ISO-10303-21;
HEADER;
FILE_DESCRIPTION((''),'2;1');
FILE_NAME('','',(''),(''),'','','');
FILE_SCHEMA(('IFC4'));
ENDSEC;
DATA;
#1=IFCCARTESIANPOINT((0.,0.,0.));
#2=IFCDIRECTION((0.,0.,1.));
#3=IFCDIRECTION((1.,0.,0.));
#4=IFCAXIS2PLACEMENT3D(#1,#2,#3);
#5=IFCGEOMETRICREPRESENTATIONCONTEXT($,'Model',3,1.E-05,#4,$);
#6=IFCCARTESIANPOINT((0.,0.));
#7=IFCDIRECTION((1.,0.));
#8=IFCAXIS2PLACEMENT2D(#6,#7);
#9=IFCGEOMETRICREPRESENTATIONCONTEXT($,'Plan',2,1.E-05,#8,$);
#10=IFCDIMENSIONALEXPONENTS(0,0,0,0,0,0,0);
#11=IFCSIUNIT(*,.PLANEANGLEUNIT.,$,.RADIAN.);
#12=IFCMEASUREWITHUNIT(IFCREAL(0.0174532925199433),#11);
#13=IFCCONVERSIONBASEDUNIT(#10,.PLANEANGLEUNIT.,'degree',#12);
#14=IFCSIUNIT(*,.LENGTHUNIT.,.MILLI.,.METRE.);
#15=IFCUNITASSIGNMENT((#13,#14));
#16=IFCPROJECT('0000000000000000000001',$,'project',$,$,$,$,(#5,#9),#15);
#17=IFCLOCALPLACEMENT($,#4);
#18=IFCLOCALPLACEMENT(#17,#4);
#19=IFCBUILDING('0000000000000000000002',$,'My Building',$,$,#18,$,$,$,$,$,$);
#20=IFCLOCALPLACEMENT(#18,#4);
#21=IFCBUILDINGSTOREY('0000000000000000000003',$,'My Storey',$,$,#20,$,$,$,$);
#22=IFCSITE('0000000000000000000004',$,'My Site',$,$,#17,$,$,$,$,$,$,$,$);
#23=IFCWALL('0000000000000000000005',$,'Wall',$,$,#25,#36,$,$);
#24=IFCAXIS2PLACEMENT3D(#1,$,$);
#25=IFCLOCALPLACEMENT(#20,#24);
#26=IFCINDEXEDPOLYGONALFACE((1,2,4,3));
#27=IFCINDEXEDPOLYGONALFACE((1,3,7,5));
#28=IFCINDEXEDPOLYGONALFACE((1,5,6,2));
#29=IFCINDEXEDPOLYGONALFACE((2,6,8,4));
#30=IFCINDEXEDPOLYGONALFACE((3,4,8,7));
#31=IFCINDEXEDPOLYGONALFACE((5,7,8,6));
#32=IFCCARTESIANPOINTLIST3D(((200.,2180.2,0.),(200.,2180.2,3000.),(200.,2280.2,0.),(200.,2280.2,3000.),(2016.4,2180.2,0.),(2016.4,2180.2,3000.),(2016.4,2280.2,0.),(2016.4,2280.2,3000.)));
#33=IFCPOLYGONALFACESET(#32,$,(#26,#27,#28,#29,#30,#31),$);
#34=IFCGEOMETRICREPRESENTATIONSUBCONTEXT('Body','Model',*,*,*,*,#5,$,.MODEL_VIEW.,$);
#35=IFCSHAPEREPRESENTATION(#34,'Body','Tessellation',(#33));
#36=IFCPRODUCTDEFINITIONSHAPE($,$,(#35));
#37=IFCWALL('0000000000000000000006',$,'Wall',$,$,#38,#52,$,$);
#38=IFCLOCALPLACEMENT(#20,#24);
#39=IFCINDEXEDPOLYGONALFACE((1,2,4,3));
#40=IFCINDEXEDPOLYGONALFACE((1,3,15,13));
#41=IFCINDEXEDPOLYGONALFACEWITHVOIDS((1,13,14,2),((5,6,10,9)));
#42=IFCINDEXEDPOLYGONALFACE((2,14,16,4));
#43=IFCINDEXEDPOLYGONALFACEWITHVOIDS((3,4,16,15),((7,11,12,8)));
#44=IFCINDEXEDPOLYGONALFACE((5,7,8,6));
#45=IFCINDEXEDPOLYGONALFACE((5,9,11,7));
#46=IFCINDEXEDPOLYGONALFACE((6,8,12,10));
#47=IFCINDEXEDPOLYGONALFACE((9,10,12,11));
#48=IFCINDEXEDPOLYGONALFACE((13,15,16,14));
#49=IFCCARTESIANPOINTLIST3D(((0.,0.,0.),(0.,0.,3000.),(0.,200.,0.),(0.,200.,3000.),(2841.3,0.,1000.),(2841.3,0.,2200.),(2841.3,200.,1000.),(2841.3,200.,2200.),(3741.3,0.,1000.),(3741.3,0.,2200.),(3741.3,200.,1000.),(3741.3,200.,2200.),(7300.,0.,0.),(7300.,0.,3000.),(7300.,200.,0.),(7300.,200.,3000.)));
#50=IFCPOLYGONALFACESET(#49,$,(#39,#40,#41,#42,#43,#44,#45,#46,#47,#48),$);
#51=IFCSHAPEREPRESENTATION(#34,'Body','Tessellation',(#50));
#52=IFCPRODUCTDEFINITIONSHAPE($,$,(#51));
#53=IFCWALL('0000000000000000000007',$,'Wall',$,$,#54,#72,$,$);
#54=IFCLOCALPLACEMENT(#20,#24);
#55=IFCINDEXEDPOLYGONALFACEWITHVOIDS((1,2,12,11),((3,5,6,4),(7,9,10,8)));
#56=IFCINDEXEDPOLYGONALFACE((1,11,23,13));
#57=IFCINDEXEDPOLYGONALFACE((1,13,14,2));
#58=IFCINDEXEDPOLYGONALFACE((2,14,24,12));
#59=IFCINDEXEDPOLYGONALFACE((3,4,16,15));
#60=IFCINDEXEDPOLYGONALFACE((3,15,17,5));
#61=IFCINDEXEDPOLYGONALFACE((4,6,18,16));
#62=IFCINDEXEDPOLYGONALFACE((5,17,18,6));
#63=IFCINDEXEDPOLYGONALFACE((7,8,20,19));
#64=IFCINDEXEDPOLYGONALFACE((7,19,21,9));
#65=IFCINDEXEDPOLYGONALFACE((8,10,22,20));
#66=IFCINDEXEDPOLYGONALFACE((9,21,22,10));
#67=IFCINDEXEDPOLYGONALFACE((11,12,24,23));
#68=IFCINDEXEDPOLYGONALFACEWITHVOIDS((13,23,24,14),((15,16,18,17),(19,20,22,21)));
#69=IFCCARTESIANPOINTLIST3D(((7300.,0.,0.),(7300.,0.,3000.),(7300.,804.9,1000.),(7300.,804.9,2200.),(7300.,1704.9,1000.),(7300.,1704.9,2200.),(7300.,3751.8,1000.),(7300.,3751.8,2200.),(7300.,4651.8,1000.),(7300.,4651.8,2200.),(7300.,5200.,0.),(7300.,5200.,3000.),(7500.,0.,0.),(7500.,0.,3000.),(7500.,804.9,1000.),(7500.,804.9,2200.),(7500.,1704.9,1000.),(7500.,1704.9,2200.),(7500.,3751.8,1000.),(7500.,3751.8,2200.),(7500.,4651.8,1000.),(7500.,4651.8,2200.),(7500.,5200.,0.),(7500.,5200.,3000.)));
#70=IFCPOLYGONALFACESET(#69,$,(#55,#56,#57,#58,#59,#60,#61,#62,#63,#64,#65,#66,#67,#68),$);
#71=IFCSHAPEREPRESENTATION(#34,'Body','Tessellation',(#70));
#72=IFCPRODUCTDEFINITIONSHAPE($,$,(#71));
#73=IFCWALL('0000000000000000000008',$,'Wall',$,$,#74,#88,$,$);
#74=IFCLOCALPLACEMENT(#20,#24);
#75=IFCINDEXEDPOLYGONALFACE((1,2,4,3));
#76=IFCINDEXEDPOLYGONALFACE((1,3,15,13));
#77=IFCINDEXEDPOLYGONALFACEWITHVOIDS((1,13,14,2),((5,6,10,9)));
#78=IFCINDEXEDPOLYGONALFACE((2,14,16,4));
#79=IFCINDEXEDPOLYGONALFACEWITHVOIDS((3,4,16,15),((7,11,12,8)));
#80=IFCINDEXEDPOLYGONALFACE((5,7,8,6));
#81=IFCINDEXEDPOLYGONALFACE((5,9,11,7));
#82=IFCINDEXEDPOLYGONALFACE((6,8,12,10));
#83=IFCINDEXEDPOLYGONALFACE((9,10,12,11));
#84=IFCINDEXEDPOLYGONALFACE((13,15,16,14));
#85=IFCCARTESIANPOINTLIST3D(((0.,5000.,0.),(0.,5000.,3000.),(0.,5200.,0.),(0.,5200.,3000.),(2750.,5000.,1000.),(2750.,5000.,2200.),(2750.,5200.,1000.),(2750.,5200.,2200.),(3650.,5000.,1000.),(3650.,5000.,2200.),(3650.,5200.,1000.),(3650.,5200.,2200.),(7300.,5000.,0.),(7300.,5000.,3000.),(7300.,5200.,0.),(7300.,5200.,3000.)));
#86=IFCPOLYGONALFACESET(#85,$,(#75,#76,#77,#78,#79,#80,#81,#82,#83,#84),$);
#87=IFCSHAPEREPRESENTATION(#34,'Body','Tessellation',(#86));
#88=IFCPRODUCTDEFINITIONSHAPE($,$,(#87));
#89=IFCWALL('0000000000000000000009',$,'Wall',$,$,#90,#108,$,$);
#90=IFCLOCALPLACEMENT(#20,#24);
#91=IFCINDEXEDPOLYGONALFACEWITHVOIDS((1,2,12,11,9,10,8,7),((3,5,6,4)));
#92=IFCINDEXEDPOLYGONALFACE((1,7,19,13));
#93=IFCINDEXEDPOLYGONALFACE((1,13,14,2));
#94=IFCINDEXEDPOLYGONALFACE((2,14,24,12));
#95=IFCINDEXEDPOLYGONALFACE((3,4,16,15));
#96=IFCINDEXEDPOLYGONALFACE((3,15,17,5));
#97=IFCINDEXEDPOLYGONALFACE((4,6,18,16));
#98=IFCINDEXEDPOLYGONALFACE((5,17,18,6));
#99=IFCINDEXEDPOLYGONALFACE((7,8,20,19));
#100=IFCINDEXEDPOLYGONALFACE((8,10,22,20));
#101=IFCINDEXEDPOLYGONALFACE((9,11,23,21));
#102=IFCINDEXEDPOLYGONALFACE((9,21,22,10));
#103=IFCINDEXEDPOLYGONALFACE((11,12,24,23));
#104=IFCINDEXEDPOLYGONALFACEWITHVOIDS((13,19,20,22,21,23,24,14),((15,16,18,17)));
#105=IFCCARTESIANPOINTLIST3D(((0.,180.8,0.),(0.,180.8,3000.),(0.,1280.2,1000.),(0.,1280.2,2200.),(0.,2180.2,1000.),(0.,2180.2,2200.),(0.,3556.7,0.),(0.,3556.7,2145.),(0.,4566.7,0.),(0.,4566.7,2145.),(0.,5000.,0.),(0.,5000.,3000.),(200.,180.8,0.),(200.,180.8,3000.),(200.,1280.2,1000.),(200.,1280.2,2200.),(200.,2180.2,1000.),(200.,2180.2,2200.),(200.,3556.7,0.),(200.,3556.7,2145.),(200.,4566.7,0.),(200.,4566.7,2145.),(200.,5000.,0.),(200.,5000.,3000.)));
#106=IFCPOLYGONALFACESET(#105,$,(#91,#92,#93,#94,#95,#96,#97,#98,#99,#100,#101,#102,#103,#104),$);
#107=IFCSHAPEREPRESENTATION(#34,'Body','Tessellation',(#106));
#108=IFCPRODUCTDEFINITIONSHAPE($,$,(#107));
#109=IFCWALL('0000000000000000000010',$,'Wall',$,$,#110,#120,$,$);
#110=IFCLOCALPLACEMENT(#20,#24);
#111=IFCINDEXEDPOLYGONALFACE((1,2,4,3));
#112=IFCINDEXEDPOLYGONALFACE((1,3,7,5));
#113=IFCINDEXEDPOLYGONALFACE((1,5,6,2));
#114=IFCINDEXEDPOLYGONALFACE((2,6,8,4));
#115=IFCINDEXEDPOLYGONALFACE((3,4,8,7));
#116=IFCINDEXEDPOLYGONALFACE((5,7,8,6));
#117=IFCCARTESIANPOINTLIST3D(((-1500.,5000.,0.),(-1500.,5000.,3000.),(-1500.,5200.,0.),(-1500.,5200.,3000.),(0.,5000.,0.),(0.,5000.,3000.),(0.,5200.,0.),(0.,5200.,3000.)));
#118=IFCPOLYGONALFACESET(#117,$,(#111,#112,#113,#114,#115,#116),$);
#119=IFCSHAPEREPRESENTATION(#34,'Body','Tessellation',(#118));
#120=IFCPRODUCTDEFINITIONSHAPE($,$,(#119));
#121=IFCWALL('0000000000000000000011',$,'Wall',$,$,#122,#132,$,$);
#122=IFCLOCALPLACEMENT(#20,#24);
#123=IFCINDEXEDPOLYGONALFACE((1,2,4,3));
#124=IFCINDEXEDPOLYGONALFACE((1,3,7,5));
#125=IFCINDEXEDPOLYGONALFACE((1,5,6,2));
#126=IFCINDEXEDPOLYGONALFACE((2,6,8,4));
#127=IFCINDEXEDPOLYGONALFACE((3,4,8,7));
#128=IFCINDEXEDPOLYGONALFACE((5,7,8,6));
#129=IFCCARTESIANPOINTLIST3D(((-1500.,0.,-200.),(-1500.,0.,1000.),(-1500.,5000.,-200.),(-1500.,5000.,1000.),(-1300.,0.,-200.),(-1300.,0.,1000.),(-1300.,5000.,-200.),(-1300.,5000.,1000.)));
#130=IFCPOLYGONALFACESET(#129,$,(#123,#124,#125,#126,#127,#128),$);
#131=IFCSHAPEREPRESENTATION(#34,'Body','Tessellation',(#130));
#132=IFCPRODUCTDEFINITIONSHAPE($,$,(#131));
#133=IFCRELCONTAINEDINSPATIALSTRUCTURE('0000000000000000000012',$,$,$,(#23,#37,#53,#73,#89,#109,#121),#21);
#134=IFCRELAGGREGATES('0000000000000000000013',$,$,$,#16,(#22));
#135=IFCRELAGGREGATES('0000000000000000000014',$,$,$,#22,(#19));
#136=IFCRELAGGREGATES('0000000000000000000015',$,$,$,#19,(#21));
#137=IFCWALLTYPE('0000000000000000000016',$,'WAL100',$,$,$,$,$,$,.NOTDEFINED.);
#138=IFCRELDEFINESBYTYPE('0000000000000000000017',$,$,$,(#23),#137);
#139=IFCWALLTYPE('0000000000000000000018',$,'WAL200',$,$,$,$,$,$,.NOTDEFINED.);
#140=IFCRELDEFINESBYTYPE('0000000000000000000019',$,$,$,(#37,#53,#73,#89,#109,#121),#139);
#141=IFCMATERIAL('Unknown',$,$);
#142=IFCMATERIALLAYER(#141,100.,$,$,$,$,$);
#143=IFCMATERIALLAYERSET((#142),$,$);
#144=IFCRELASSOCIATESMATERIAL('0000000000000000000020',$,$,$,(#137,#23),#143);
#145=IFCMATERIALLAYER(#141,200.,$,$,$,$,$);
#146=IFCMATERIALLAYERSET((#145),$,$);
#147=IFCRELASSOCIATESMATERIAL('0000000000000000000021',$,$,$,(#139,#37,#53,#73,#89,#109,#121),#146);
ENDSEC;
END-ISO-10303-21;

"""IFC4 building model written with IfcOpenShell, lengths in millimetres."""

from ifc_helpers import new_model, entity, si_unit, converted_unit, frame, origin_with_axes, origin_2d_with_axis, place, context, subcontext, project, spatial, line, indexed_curve, outline, extrude, source, transform, mapped, material, layer, layer_set, layer_usage, type_object, element, save


model = new_model("IFC4")

# Units and contexts
model_context = context("Model", 3, precision=1e-05, world=origin_with_axes())
plan_context = context("Plan", 2, precision=1e-05, world=origin_2d_with_axis())
body_context = subcontext(model_context, "Body", "Model", "MODEL_VIEW")
ifc_project = project(units=[converted_unit("PLANEANGLEUNIT", "degree", entity("IfcReal", 0.0174532925199433), si_unit("PLANEANGLEUNIT", "RADIAN"), dimensions=[0, 0, 0, 0, 0, 0, 0]), si_unit("LENGTHUNIT", "METRE", prefix="MILLI")], contexts=[model_context, plan_context])

# Site, building, storey
site_placement = place(None, origin_with_axes())
site = spatial("IfcSite", under=ifc_project, at=site_placement, Name="My Site")
building_placement = place(site_placement, origin_with_axes())
building = spatial("IfcBuilding", under=site, at=building_placement, Name="My Building")
storey_placement = place(building_placement, origin_with_axes())
storey = spatial("IfcBuildingStorey", under=building, at=storey_placement, Name="My Storey")

# Shared definitions
ifc_material = material(Name="Unknown")

# Shared definitions
ifc_layer_1 = layer(ifc_material, 100.0)
ifc_layer_set_1 = layer_set([ifc_layer_1])
wall_type_1 = type_object("IfcWallType", Name="WAL100", PredefinedType="NOTDEFINED", material=ifc_layer_set_1)
shared_shape_1 = source(origin_with_axes(), body_context, "Body", "SweptSolid", [
    extrude(outline(indexed_curve([(0.0, 0.0), (1010.0, 0.0), (1010.0, 2145.0), (0.0, 2145.0)], segments=[line(1, 2), line(2, 3), line(3, 4), line(4, 1)])), frame((0.0, -100.0, 0.0), z_axis=(0.0, -1.0, 0.0), x_axis=(1.0, 0.0, 0.0)), (0.0, 0.0, -1.0), 400.0),
])

# Wall
ifc_layer_usage_1 = layer_usage(ifc_layer_set_1, "AXIS2", "POSITIVE", 0.0)
wall_1_placement = place(storey_placement, frame((200.0, 2180.2, 0.0), z_axis=(0.0, 0.0, 1.0), x_axis=(1.0, 0.0, 0.0)))
element("IfcWall", 1, at=wall_1_placement, inside=storey, type_object=wall_type_1, material=ifc_layer_usage_1, Name="Wall", context=body_context, shape_type="SweptSolid", body=[
    extrude(outline(indexed_curve([(0.0, 0.0), (0.0, 100.0), (1816.4, 100.0), (1816.4, 0.0), (0.0, 0.0)], self_intersect=False)), origin_with_axes(), (0.0, 0.0, 1.0), 3000.0),
])

# Wall, opening
ifc_layer_2 = layer(ifc_material, 200.0)
ifc_layer_set_2 = layer_set([ifc_layer_2])
ifc_layer_usage_2 = layer_usage(ifc_layer_set_2, "AXIS2", "POSITIVE", 0.0)
wall_type_2 = type_object("IfcWallType", Name="WAL200", PredefinedType="NOTDEFINED", material=ifc_layer_set_2)
wall_2_placement = place(storey_placement, origin_with_axes())
wall_2 = element("IfcWall", 2, at=wall_2_placement, inside=storey, type_object=wall_type_2, material=ifc_layer_usage_2, Name="Wall", context=body_context, shape_type="SweptSolid", body=[
    extrude(outline(indexed_curve([(0.0, 0.0), (0.0, 200.0), (7300.0, 200.0), (7300.0, 0.0), (0.0, 0.0)], self_intersect=False)), origin_with_axes(), (0.0, 0.0, 1.0), 3000.0),
])
shared_shape_2 = source(origin_with_axes(), body_context, "Body", "SweptSolid", [
    extrude(outline(indexed_curve([(0.0, 0.0), (900.0, 0.0), (900.0, 1200.0), (0.0, 1200.0)], segments=[line(1, 2), line(2, 3), line(3, 4), line(4, 1)])), frame((0.0, -100.0, 0.0), z_axis=(0.0, -1.0, 0.0), x_axis=(1.0, 0.0, 0.0)), (0.0, 0.0, -1.0), 400.0),
])
opening_1_placement = place(wall_2_placement, frame((2841.3, 0.0, 1000.0), z_axis=(0.0, 0.0, 1.0), x_axis=(1.0, 0.0, 0.0)))
element("IfcOpeningElement", 3, at=opening_1_placement, cuts=wall_2, PredefinedType="OPENING", context=body_context, shape_type="MappedRepresentation", body=[
    mapped(shared_shape_2, transform((0.0, 0.0, 0.0), x_axis=(1.0, 0.0, 0.0), y_axis=(0.0, 1.0, 0.0), z_axis=(0.0, 0.0, 1.0), scale=1.0)),
])

# Wall, openings
ifc_layer_usage_3 = layer_usage(ifc_layer_set_2, "AXIS2", "POSITIVE", 0.0)
wall_3_placement = place(storey_placement, frame((7500.0, 0.0, 0.0), z_axis=(0.0, 0.0, 1.0), x_axis=(0.0, 1.0, 0.0)))
wall_3 = element("IfcWall", 4, at=wall_3_placement, inside=storey, type_object=wall_type_2, material=ifc_layer_usage_3, Name="Wall", context=body_context, shape_type="SweptSolid", body=[
    extrude(outline(indexed_curve([(0.0, 0.0), (0.0, 200.0), (5200.0, 200.0), (5200.0, 0.0), (0.0, 0.0)], self_intersect=False)), origin_with_axes(), (0.0, 0.0, 1.0), 3000.0),
])
opening_2_placement = place(wall_3_placement, frame((3751.8, 0.0, 1000.0), z_axis=(0.0, 0.0, 1.0), x_axis=(1.0, 0.0, 0.0)))
element("IfcOpeningElement", 5, at=opening_2_placement, cuts=wall_3, PredefinedType="OPENING", context=body_context, shape_type="MappedRepresentation", body=[
    mapped(shared_shape_2, transform((0.0, 0.0, 0.0), x_axis=(1.0, 0.0, 0.0), y_axis=(0.0, 1.0, 0.0), z_axis=(0.0, 0.0, 1.0), scale=1.0)),
])
opening_3_placement = place(wall_3_placement, frame((804.9, 0.0, 1000.0), z_axis=(0.0, 0.0, 1.0), x_axis=(1.0, 0.0, 0.0)))
element("IfcOpeningElement", 6, at=opening_3_placement, cuts=wall_3, PredefinedType="OPENING", context=body_context, shape_type="MappedRepresentation", body=[
    mapped(shared_shape_2, transform((0.0, 0.0, 0.0), x_axis=(1.0, 0.0, 0.0), y_axis=(0.0, 1.0, 0.0), z_axis=(0.0, 0.0, 1.0), scale=1.0)),
])

# Wall, opening
ifc_layer_usage_4 = layer_usage(ifc_layer_set_2, "AXIS2", "POSITIVE", 0.0)
wall_4_placement = place(storey_placement, frame((7300.0, 5200.0, 0.0), z_axis=(0.0, 0.0, 1.0), x_axis=(-1.0, 0.0, 0.0)))
wall_4 = element("IfcWall", 7, at=wall_4_placement, inside=storey, type_object=wall_type_2, material=ifc_layer_usage_4, Name="Wall", context=body_context, shape_type="SweptSolid", body=[
    extrude(outline(indexed_curve([(0.0, 0.0), (0.0, 200.0), (7300.0, 200.0), (7300.0, 0.0), (0.0, 0.0)], self_intersect=False)), origin_with_axes(), (0.0, 0.0, 1.0), 3000.0),
])
opening_4_placement = place(wall_4_placement, frame((3650.0, 0.0, 1000.0), z_axis=(0.0, 0.0, 1.0), x_axis=(1.0, 0.0, 0.0)))
element("IfcOpeningElement", 8, at=opening_4_placement, cuts=wall_4, PredefinedType="OPENING", context=body_context, shape_type="MappedRepresentation", body=[
    mapped(shared_shape_2, transform((0.0, 0.0, 0.0), x_axis=(1.0, 0.0, 0.0), y_axis=(0.0, 1.0, 0.0), z_axis=(0.0, 0.0, 1.0), scale=1.0)),
])

# Wall, openings
ifc_layer_usage_5 = layer_usage(ifc_layer_set_2, "AXIS2", "POSITIVE", 0.0)
wall_5_placement = place(storey_placement, frame((0.0, 5000.0, 0.0), z_axis=(0.0, 0.0, 1.0), x_axis=(0.0, -1.0, 0.0)))
wall_5 = element("IfcWall", 9, at=wall_5_placement, inside=storey, type_object=wall_type_2, material=ifc_layer_usage_5, Name="Wall", context=body_context, shape_type="SweptSolid", body=[
    extrude(outline(indexed_curve([(0.0, 0.0), (0.0, 200.0), (4819.2, 200.0), (4819.2, 0.0), (0.0, 0.0)], self_intersect=False)), origin_with_axes(), (0.0, 0.0, 1.0), 3000.0),
])
opening_5_placement = place(wall_5_placement, frame((433.4, 0.0, 0.0), z_axis=(0.0, 0.0, 1.0), x_axis=(1.0, 0.0, 0.0)))
element("IfcOpeningElement", 10, at=opening_5_placement, cuts=wall_5, PredefinedType="OPENING", context=body_context, shape_type="MappedRepresentation", body=[
    mapped(shared_shape_1, transform((0.0, 0.0, 0.0), x_axis=(1.0, 0.0, 0.0), y_axis=(0.0, 1.0, 0.0), z_axis=(0.0, 0.0, 1.0), scale=1.0)),
])
opening_6_placement = place(wall_5_placement, frame((2819.8, 0.0, 1000.0), z_axis=(0.0, 0.0, 1.0), x_axis=(1.0, 0.0, 0.0)))
element("IfcOpeningElement", 11, at=opening_6_placement, cuts=wall_5, PredefinedType="OPENING", context=body_context, shape_type="MappedRepresentation", body=[
    mapped(shared_shape_2, transform((0.0, 0.0, 0.0), x_axis=(1.0, 0.0, 0.0), y_axis=(0.0, 1.0, 0.0), z_axis=(0.0, 0.0, 1.0), scale=1.0)),
])

# Walls
ifc_layer_usage_6 = layer_usage(ifc_layer_set_2, "AXIS2", "POSITIVE", 0.0)
wall_6_placement = place(storey_placement, frame((0.0, 5200.0, 0.0), z_axis=(0.0, 0.0, 1.0), x_axis=(-1.0, 0.000001, 0.0)))
element("IfcWall", 12, at=wall_6_placement, inside=storey, type_object=wall_type_2, material=ifc_layer_usage_6, Name="Wall", context=body_context, shape_type="SweptSolid", body=[
    extrude(outline(indexed_curve([(0.0, 0.0), (0.0, 200.0), (1500.0, 200.0), (1500.0, 0.0), (0.0, 0.0)], self_intersect=False)), origin_with_axes(), (0.0, 0.0, 1.0), 3000.0),
])
ifc_layer_usage_7 = layer_usage(ifc_layer_set_2, "AXIS2", "POSITIVE", 0.0)
wall_7_placement = place(storey_placement, frame((-1500.0, 5000.0, -200.0), z_axis=(0.0, 0.0, 1.0), x_axis=(-0.000001, -1.0, 0.0)))
element("IfcWall", 13, at=wall_7_placement, inside=storey, type_object=wall_type_2, material=ifc_layer_usage_7, Name="Wall", context=body_context, shape_type="SweptSolid", body=[
    extrude(outline(indexed_curve([(0.0, 0.0), (0.0, 200.0), (5000.0, 200.0), (5000.0, 0.0), (0.0, 0.0)], self_intersect=False)), origin_with_axes(), (0.0, 0.0, 1.0), 1200.0),
])

save(model, "model.ifc")
